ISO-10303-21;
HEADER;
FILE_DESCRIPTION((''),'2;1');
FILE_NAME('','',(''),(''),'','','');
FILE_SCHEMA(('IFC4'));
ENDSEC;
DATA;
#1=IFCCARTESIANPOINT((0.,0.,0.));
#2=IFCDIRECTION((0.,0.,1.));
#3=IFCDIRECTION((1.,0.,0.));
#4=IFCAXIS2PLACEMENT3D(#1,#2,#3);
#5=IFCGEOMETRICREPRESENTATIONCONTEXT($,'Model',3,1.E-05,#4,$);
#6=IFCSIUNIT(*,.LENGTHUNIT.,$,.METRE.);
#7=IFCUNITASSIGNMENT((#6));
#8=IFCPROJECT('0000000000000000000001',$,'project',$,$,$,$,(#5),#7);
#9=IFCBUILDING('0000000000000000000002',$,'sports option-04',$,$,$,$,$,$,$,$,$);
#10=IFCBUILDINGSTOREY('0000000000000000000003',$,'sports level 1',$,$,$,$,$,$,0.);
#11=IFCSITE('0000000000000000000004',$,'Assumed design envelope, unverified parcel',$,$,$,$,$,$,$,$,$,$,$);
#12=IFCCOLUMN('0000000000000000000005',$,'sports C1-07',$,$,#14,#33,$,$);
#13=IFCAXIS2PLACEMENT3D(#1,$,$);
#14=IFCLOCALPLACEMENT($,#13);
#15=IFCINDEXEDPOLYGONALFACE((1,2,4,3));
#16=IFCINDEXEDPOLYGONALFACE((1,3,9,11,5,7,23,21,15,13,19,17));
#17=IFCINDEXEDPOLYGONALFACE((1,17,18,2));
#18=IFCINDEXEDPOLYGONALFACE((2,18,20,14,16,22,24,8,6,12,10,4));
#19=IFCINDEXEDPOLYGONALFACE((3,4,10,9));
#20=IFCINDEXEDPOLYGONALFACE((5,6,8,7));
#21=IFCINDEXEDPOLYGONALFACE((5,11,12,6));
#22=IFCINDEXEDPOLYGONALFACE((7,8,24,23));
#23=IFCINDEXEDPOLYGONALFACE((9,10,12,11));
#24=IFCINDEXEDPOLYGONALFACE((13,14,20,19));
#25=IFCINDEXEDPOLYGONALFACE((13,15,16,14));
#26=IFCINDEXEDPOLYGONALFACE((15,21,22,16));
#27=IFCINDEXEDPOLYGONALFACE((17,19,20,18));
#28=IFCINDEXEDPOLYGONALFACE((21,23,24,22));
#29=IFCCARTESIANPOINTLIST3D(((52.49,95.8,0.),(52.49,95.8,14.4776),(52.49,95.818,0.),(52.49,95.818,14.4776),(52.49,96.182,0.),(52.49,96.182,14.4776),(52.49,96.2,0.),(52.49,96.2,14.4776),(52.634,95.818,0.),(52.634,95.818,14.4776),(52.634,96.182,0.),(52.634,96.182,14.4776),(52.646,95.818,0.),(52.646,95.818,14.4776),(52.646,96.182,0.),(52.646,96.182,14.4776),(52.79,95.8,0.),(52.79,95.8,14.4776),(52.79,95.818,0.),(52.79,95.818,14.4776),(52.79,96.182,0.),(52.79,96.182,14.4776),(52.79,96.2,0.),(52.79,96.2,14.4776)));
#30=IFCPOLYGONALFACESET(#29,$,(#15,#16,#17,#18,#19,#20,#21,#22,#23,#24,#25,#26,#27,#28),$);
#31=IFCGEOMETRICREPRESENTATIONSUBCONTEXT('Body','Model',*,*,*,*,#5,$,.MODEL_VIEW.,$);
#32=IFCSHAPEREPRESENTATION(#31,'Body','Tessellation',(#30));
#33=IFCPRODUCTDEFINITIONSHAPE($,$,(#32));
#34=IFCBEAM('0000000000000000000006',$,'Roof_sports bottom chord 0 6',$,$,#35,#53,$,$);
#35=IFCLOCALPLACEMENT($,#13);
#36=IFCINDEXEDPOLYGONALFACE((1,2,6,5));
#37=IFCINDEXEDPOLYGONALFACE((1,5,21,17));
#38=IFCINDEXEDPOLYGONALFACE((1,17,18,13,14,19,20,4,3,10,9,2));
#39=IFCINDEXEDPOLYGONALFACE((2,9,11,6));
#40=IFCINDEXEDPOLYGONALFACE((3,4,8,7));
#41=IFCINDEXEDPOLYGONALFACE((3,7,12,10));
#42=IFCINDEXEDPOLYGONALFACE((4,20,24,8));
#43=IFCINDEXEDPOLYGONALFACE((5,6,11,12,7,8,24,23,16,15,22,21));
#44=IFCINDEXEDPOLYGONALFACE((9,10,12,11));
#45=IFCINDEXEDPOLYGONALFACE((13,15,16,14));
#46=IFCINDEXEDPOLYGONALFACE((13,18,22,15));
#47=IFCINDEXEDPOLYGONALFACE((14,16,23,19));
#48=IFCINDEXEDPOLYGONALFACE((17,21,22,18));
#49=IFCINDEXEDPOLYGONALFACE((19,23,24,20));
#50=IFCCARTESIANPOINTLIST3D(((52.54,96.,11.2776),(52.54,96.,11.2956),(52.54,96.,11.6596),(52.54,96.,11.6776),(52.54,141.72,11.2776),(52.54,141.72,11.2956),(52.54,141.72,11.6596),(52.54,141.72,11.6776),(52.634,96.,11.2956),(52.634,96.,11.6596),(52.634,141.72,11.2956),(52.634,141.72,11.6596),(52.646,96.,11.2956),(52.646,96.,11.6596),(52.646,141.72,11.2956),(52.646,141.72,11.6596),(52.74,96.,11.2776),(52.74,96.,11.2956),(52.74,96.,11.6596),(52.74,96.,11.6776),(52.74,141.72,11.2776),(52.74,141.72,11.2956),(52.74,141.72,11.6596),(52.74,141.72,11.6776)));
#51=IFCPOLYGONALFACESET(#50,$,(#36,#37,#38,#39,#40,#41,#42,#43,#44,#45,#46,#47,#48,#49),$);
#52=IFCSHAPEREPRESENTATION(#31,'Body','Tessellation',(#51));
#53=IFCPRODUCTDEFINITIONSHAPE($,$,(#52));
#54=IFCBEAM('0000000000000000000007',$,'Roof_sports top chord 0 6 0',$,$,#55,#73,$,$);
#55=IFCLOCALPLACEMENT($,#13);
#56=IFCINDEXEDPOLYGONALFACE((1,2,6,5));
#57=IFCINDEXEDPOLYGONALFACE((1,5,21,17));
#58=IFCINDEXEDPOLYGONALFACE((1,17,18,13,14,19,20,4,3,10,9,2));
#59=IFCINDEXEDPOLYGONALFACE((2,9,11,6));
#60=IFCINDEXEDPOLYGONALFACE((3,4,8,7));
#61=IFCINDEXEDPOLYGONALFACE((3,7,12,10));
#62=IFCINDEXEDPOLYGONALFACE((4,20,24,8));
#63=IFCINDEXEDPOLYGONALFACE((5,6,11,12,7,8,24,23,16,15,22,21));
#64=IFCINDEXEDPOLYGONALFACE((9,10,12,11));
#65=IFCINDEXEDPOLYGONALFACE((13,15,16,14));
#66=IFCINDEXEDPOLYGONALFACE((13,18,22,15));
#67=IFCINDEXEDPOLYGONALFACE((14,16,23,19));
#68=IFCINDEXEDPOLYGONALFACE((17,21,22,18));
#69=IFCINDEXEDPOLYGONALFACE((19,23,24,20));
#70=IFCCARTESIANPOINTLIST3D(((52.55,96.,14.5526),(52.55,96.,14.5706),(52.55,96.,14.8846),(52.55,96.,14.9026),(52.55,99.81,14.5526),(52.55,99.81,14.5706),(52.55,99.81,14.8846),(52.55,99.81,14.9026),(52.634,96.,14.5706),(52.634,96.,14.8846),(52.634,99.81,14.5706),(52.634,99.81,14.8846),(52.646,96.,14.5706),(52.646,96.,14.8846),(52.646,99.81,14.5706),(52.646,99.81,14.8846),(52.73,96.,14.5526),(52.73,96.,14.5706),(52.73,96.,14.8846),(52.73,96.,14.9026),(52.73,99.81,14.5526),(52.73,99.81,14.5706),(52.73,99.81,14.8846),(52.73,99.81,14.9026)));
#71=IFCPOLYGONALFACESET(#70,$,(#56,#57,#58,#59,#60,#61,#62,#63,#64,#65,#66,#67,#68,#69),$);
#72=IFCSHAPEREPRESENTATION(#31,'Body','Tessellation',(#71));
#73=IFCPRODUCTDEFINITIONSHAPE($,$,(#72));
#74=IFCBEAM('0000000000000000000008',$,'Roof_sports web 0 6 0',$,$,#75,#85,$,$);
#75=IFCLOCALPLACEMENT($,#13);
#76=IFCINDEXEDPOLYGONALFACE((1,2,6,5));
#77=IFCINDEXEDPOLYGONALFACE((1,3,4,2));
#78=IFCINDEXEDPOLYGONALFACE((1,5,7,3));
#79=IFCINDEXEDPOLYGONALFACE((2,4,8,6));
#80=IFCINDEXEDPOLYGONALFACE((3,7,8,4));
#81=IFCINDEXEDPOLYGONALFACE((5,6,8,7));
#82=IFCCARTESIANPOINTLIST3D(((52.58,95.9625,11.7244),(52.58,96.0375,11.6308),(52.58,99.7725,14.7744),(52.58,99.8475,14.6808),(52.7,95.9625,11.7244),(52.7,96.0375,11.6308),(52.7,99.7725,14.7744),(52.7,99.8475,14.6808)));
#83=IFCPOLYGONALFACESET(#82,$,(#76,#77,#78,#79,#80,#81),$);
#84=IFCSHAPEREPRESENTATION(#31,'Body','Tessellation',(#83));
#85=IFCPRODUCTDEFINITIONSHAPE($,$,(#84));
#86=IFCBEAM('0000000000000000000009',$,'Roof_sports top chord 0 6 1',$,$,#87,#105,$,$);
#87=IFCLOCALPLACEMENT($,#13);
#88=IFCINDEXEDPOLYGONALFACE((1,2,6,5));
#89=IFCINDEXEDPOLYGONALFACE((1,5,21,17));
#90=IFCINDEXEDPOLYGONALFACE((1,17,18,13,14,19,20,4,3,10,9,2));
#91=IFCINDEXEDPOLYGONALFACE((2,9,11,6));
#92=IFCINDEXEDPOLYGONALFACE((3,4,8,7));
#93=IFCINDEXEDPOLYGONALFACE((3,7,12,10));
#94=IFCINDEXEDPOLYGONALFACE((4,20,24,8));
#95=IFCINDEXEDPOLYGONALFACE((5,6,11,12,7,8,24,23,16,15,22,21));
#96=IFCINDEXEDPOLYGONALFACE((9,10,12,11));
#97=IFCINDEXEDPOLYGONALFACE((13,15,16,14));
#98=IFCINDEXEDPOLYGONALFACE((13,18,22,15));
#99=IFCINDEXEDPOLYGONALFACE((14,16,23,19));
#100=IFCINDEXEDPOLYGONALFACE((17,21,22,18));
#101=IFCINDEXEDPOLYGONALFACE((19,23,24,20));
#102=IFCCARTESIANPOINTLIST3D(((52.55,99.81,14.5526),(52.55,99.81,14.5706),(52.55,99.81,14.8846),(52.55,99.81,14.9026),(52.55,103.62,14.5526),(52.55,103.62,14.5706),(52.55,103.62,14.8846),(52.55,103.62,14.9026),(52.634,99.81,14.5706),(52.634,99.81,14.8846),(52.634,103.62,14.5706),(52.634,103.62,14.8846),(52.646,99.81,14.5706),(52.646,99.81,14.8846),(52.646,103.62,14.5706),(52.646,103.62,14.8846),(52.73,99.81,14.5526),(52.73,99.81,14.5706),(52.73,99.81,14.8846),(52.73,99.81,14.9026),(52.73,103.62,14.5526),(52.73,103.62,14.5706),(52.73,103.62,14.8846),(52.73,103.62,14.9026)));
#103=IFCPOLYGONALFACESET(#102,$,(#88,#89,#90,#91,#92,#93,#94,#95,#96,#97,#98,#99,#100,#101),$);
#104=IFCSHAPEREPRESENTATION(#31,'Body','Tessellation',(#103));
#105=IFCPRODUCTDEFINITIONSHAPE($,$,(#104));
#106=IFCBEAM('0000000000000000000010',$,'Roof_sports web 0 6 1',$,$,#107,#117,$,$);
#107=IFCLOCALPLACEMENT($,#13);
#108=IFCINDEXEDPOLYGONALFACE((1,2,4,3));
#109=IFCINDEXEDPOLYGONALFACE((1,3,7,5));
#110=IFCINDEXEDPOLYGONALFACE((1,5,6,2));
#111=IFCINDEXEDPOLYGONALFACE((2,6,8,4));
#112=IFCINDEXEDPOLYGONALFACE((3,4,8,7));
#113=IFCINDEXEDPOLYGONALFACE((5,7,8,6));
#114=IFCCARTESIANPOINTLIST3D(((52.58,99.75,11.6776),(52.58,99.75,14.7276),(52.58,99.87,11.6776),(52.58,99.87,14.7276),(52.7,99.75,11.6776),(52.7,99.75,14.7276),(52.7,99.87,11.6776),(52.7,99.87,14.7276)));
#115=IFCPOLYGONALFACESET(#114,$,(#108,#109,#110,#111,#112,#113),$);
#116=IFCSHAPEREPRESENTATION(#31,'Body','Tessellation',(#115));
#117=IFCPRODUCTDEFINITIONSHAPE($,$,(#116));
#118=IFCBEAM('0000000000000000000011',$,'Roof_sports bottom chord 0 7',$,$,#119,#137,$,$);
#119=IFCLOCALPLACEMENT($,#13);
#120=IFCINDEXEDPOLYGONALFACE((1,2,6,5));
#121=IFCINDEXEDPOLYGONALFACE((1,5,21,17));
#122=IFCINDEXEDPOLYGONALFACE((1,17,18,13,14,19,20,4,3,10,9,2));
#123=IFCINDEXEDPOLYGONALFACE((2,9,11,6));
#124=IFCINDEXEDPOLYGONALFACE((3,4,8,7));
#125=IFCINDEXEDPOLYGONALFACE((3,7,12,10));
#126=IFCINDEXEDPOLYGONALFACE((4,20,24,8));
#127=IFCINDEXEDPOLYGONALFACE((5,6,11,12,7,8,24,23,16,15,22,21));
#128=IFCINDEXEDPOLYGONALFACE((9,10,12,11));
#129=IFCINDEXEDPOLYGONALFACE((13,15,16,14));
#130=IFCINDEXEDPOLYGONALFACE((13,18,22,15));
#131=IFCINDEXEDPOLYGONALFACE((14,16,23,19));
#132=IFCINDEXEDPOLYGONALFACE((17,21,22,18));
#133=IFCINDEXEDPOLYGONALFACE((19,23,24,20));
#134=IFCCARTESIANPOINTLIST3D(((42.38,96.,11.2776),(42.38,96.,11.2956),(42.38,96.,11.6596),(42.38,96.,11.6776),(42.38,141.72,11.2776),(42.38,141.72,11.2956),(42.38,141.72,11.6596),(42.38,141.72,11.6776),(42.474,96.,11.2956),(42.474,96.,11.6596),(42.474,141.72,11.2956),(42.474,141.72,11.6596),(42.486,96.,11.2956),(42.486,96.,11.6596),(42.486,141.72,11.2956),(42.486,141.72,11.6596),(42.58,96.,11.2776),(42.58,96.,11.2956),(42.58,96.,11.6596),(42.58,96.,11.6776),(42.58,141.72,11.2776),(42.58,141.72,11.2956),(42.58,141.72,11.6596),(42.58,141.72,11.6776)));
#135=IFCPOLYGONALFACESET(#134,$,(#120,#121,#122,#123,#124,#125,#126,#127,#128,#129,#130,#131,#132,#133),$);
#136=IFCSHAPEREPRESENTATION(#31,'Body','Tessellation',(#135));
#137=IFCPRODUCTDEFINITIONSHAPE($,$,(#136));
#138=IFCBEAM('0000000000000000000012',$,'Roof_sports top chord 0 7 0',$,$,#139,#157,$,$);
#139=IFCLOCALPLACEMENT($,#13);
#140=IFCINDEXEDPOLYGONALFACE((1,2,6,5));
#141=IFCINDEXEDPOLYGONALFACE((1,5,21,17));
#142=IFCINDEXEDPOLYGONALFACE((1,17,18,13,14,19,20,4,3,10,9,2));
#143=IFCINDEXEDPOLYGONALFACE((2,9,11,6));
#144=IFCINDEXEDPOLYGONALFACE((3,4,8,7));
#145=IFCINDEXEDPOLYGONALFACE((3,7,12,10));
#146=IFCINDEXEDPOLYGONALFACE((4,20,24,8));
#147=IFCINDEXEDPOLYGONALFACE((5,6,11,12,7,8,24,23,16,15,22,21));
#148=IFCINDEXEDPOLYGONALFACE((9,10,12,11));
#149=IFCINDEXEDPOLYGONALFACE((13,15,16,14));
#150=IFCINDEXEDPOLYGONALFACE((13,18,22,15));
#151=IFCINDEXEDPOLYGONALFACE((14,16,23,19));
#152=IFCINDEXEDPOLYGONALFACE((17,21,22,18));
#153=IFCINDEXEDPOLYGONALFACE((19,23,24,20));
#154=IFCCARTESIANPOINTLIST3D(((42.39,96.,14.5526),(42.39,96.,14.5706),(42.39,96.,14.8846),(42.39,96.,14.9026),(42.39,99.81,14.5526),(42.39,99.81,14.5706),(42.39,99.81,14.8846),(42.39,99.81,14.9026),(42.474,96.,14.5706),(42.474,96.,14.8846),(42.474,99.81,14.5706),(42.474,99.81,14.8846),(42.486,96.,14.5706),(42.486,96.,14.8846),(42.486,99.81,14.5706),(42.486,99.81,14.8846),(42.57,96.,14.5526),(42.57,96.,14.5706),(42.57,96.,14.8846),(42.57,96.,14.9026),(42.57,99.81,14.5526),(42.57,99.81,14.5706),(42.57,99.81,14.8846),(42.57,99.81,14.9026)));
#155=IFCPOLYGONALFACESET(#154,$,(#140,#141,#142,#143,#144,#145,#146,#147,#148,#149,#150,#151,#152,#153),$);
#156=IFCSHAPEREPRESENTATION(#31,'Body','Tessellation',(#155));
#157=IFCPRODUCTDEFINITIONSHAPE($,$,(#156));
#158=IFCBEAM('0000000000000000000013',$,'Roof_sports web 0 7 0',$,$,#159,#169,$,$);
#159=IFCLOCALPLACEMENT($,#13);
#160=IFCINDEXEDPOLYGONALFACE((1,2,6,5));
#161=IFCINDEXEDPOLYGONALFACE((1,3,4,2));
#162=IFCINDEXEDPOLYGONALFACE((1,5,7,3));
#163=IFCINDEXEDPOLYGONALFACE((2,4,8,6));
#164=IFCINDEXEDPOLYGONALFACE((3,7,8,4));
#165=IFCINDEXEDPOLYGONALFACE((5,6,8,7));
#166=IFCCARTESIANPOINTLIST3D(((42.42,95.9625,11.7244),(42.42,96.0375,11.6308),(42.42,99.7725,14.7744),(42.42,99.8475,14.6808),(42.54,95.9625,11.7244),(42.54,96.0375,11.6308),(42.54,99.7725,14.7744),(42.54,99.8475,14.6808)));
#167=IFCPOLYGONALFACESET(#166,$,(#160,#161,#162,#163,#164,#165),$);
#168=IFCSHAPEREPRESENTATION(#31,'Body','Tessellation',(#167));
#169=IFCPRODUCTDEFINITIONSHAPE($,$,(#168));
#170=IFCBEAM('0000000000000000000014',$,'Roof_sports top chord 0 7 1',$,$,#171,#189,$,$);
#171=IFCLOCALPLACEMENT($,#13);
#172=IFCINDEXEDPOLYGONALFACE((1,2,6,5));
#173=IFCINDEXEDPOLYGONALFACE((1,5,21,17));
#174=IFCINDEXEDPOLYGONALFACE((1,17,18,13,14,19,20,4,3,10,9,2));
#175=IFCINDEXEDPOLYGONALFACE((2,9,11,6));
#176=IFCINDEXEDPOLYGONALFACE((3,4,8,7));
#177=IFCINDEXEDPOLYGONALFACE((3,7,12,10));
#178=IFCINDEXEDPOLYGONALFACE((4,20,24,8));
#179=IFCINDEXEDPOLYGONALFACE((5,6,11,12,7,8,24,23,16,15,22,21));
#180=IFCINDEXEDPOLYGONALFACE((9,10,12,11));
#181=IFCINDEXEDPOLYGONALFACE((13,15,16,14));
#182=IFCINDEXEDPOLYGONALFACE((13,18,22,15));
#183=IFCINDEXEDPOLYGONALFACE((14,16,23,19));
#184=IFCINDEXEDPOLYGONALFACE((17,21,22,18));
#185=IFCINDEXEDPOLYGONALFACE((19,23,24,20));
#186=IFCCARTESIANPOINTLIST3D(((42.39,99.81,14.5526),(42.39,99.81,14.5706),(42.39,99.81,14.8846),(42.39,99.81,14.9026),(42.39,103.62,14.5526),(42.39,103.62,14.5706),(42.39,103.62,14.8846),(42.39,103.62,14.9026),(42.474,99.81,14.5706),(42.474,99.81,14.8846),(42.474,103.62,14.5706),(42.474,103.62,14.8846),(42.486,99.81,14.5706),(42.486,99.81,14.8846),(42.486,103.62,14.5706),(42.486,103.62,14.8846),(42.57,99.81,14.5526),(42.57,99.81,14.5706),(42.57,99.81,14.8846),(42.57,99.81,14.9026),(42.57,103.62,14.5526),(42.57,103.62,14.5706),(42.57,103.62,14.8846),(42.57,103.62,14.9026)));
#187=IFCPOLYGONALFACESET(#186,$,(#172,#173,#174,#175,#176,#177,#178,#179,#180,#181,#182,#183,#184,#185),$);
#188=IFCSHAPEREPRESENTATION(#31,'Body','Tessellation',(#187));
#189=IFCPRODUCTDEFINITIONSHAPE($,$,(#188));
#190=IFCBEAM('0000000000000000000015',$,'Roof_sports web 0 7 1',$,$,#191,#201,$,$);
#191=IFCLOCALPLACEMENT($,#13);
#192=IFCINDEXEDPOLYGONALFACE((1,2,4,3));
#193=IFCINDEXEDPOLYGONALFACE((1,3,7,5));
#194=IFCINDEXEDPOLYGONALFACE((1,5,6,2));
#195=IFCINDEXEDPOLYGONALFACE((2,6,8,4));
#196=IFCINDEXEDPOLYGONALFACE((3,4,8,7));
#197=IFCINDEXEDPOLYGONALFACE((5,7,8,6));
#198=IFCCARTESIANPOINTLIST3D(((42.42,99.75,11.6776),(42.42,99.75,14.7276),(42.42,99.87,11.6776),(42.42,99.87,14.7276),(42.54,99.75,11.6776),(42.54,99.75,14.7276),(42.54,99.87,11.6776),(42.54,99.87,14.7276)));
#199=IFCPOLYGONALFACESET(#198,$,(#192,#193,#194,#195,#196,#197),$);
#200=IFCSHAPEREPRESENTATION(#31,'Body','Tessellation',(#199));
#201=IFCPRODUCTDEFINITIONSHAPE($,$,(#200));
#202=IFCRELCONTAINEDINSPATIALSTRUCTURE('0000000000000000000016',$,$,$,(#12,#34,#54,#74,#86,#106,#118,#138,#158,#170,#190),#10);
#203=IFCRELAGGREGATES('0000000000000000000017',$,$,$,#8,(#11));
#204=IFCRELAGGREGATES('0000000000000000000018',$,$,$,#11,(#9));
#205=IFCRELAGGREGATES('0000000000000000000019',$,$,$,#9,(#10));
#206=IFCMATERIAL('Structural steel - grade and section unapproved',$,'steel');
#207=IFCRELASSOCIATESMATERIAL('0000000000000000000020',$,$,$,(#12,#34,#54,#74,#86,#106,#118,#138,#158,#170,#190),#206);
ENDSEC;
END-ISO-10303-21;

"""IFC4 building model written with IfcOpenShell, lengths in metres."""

from ifc_helpers import new_model, si_unit, frame, origin_with_axes, place, context, subcontext, project, spatial, rectangle, i_section, extrude, material, element, save


model = new_model("IFC4")

# Units and contexts
model_context = context("Model", 3, precision=1e-05, world=origin_with_axes())
body_context = subcontext(model_context, "Body", "Model", "MODEL_VIEW")
ifc_project = project(units=[si_unit("LENGTHUNIT", "METRE")], contexts=[model_context])

# Site, building, storey
site = spatial("IfcSite", under=ifc_project, Name="Assumed design envelope, unverified parcel")
building = spatial("IfcBuilding", under=site, Name="sports option-04")
storey = spatial("IfcBuildingStorey", under=building, Name="sports level 1", Elevation=0.0)

# Column
ifc_material_1 = material(Name="Structural steel - grade and section unapproved", Category="steel")
column_placement = place(None, frame((52.64, 96.0, 0.0), z_axis=(0.0, 0.0, 1.0), x_axis=(-1.0, 0.0, 0.0)))
element("IfcColumn", 1, at=column_placement, inside=storey, material=ifc_material_1, Name="sports C1-07", context=body_context, shape_type="SweptSolid", body=[
    extrude(i_section(OverallWidth=0.3, OverallDepth=0.4, WebThickness=0.012, FlangeThickness=0.018, FilletRadius=0.0), origin_with_axes(), (0.0, 0.0, 1.0), 14.4776),
])

# Beams
beam_1_placement = place(None, frame((52.64, 96.0, 11.4776), z_axis=(0.0, 1.0, 0.0), x_axis=(-1.0, 0.0, 0.0)))
element("IfcBeam", 2, at=beam_1_placement, inside=storey, material=ifc_material_1, Name="Roof_sports bottom chord 0 6", context=body_context, shape_type="SweptSolid", body=[
    extrude(i_section(OverallWidth=0.2, OverallDepth=0.4, WebThickness=0.012, FlangeThickness=0.018, FilletRadius=0.0), origin_with_axes(), (0.0, 0.0, 1.0), 45.72),
])
beam_2_placement = place(None, frame((52.64, 96.0, 14.7276), z_axis=(0.0, 1.0, 0.0), x_axis=(-1.0, 0.0, 0.0)))
element("IfcBeam", 3, at=beam_2_placement, inside=storey, material=ifc_material_1, Name="Roof_sports top chord 0 6 0", context=body_context, shape_type="SweptSolid", body=[
    extrude(i_section(OverallWidth=0.18, OverallDepth=0.35, WebThickness=0.012, FlangeThickness=0.018, FilletRadius=0.0), origin_with_axes(), (0.0, 0.0, 1.0), 3.81),
])
beam_3_placement = place(None, frame((52.64, 96.0, 11.6776), z_axis=(0.0, 0.780669, 0.624945), x_axis=(-1.0, 0.0, 0.0)))
element("IfcBeam", 4, at=beam_3_placement, inside=storey, material=ifc_material_1, Name="Roof_sports web 0 6 0", context=body_context, shape_type="SweptSolid", body=[
    extrude(rectangle(XDim=0.12, YDim=0.12), origin_with_axes(), (0.0, 0.0, 1.0), 4.8804),
])
beam_4_placement = place(None, frame((52.64, 99.81, 14.7276), z_axis=(0.0, 1.0, 0.0), x_axis=(-1.0, 0.0, 0.0)))
element("IfcBeam", 5, at=beam_4_placement, inside=storey, material=ifc_material_1, Name="Roof_sports top chord 0 6 1", context=body_context, shape_type="SweptSolid", body=[
    extrude(i_section(OverallWidth=0.18, OverallDepth=0.35, WebThickness=0.012, FlangeThickness=0.018, FilletRadius=0.0), origin_with_axes(), (0.0, 0.0, 1.0), 3.81),
])
beam_5_placement = place(None, frame((52.64, 99.81, 11.6776), z_axis=(0.0, 0.0, 1.0), x_axis=(-1.0, 0.0, 0.0)))
element("IfcBeam", 6, at=beam_5_placement, inside=storey, material=ifc_material_1, Name="Roof_sports web 0 6 1", context=body_context, shape_type="SweptSolid", body=[
    extrude(rectangle(XDim=0.12, YDim=0.12), origin_with_axes(), (0.0, 0.0, 1.0), 3.05),
])
beam_6_placement = place(None, frame((42.48, 96.0, 11.4776), z_axis=(0.0, 1.0, 0.0), x_axis=(-1.0, 0.0, 0.0)))
element("IfcBeam", 7, at=beam_6_placement, inside=storey, material=ifc_material_1, Name="Roof_sports bottom chord 0 7", context=body_context, shape_type="SweptSolid", body=[
    extrude(i_section(OverallWidth=0.2, OverallDepth=0.4, WebThickness=0.012, FlangeThickness=0.018, FilletRadius=0.0), origin_with_axes(), (0.0, 0.0, 1.0), 45.72),
])
beam_7_placement = place(None, frame((42.48, 96.0, 14.7276), z_axis=(0.0, 1.0, 0.0), x_axis=(-1.0, 0.0, 0.0)))
element("IfcBeam", 8, at=beam_7_placement, inside=storey, material=ifc_material_1, Name="Roof_sports top chord 0 7 0", context=body_context, shape_type="SweptSolid", body=[
    extrude(i_section(OverallWidth=0.18, OverallDepth=0.35, WebThickness=0.012, FlangeThickness=0.018, FilletRadius=0.0), origin_with_axes(), (0.0, 0.0, 1.0), 3.81),
])
beam_8_placement = place(None, frame((42.48, 96.0, 11.6776), z_axis=(0.0, 0.780669, 0.624945), x_axis=(-1.0, 0.0, 0.0)))
element("IfcBeam", 9, at=beam_8_placement, inside=storey, material=ifc_material_1, Name="Roof_sports web 0 7 0", context=body_context, shape_type="SweptSolid", body=[
    extrude(rectangle(XDim=0.12, YDim=0.12), origin_with_axes(), (0.0, 0.0, 1.0), 4.8804),
])
beam_9_placement = place(None, frame((42.48, 99.81, 14.7276), z_axis=(0.0, 1.0, 0.0), x_axis=(-1.0, 0.0, 0.0)))
element("IfcBeam", 10, at=beam_9_placement, inside=storey, material=ifc_material_1, Name="Roof_sports top chord 0 7 1", context=body_context, shape_type="SweptSolid", body=[
    extrude(i_section(OverallWidth=0.18, OverallDepth=0.35, WebThickness=0.012, FlangeThickness=0.018, FilletRadius=0.0), origin_with_axes(), (0.0, 0.0, 1.0), 3.81),
])
beam_10_placement = place(None, frame((42.48, 99.81, 11.6776), z_axis=(0.0, 0.0, 1.0), x_axis=(-1.0, 0.0, 0.0)))
element("IfcBeam", 11, at=beam_10_placement, inside=storey, material=ifc_material_1, Name="Roof_sports web 0 7 1", context=body_context, shape_type="SweptSolid", body=[
    extrude(rectangle(XDim=0.12, YDim=0.12), origin_with_axes(), (0.0, 0.0, 1.0), 3.05),
])

save(model, "model.ifc")
